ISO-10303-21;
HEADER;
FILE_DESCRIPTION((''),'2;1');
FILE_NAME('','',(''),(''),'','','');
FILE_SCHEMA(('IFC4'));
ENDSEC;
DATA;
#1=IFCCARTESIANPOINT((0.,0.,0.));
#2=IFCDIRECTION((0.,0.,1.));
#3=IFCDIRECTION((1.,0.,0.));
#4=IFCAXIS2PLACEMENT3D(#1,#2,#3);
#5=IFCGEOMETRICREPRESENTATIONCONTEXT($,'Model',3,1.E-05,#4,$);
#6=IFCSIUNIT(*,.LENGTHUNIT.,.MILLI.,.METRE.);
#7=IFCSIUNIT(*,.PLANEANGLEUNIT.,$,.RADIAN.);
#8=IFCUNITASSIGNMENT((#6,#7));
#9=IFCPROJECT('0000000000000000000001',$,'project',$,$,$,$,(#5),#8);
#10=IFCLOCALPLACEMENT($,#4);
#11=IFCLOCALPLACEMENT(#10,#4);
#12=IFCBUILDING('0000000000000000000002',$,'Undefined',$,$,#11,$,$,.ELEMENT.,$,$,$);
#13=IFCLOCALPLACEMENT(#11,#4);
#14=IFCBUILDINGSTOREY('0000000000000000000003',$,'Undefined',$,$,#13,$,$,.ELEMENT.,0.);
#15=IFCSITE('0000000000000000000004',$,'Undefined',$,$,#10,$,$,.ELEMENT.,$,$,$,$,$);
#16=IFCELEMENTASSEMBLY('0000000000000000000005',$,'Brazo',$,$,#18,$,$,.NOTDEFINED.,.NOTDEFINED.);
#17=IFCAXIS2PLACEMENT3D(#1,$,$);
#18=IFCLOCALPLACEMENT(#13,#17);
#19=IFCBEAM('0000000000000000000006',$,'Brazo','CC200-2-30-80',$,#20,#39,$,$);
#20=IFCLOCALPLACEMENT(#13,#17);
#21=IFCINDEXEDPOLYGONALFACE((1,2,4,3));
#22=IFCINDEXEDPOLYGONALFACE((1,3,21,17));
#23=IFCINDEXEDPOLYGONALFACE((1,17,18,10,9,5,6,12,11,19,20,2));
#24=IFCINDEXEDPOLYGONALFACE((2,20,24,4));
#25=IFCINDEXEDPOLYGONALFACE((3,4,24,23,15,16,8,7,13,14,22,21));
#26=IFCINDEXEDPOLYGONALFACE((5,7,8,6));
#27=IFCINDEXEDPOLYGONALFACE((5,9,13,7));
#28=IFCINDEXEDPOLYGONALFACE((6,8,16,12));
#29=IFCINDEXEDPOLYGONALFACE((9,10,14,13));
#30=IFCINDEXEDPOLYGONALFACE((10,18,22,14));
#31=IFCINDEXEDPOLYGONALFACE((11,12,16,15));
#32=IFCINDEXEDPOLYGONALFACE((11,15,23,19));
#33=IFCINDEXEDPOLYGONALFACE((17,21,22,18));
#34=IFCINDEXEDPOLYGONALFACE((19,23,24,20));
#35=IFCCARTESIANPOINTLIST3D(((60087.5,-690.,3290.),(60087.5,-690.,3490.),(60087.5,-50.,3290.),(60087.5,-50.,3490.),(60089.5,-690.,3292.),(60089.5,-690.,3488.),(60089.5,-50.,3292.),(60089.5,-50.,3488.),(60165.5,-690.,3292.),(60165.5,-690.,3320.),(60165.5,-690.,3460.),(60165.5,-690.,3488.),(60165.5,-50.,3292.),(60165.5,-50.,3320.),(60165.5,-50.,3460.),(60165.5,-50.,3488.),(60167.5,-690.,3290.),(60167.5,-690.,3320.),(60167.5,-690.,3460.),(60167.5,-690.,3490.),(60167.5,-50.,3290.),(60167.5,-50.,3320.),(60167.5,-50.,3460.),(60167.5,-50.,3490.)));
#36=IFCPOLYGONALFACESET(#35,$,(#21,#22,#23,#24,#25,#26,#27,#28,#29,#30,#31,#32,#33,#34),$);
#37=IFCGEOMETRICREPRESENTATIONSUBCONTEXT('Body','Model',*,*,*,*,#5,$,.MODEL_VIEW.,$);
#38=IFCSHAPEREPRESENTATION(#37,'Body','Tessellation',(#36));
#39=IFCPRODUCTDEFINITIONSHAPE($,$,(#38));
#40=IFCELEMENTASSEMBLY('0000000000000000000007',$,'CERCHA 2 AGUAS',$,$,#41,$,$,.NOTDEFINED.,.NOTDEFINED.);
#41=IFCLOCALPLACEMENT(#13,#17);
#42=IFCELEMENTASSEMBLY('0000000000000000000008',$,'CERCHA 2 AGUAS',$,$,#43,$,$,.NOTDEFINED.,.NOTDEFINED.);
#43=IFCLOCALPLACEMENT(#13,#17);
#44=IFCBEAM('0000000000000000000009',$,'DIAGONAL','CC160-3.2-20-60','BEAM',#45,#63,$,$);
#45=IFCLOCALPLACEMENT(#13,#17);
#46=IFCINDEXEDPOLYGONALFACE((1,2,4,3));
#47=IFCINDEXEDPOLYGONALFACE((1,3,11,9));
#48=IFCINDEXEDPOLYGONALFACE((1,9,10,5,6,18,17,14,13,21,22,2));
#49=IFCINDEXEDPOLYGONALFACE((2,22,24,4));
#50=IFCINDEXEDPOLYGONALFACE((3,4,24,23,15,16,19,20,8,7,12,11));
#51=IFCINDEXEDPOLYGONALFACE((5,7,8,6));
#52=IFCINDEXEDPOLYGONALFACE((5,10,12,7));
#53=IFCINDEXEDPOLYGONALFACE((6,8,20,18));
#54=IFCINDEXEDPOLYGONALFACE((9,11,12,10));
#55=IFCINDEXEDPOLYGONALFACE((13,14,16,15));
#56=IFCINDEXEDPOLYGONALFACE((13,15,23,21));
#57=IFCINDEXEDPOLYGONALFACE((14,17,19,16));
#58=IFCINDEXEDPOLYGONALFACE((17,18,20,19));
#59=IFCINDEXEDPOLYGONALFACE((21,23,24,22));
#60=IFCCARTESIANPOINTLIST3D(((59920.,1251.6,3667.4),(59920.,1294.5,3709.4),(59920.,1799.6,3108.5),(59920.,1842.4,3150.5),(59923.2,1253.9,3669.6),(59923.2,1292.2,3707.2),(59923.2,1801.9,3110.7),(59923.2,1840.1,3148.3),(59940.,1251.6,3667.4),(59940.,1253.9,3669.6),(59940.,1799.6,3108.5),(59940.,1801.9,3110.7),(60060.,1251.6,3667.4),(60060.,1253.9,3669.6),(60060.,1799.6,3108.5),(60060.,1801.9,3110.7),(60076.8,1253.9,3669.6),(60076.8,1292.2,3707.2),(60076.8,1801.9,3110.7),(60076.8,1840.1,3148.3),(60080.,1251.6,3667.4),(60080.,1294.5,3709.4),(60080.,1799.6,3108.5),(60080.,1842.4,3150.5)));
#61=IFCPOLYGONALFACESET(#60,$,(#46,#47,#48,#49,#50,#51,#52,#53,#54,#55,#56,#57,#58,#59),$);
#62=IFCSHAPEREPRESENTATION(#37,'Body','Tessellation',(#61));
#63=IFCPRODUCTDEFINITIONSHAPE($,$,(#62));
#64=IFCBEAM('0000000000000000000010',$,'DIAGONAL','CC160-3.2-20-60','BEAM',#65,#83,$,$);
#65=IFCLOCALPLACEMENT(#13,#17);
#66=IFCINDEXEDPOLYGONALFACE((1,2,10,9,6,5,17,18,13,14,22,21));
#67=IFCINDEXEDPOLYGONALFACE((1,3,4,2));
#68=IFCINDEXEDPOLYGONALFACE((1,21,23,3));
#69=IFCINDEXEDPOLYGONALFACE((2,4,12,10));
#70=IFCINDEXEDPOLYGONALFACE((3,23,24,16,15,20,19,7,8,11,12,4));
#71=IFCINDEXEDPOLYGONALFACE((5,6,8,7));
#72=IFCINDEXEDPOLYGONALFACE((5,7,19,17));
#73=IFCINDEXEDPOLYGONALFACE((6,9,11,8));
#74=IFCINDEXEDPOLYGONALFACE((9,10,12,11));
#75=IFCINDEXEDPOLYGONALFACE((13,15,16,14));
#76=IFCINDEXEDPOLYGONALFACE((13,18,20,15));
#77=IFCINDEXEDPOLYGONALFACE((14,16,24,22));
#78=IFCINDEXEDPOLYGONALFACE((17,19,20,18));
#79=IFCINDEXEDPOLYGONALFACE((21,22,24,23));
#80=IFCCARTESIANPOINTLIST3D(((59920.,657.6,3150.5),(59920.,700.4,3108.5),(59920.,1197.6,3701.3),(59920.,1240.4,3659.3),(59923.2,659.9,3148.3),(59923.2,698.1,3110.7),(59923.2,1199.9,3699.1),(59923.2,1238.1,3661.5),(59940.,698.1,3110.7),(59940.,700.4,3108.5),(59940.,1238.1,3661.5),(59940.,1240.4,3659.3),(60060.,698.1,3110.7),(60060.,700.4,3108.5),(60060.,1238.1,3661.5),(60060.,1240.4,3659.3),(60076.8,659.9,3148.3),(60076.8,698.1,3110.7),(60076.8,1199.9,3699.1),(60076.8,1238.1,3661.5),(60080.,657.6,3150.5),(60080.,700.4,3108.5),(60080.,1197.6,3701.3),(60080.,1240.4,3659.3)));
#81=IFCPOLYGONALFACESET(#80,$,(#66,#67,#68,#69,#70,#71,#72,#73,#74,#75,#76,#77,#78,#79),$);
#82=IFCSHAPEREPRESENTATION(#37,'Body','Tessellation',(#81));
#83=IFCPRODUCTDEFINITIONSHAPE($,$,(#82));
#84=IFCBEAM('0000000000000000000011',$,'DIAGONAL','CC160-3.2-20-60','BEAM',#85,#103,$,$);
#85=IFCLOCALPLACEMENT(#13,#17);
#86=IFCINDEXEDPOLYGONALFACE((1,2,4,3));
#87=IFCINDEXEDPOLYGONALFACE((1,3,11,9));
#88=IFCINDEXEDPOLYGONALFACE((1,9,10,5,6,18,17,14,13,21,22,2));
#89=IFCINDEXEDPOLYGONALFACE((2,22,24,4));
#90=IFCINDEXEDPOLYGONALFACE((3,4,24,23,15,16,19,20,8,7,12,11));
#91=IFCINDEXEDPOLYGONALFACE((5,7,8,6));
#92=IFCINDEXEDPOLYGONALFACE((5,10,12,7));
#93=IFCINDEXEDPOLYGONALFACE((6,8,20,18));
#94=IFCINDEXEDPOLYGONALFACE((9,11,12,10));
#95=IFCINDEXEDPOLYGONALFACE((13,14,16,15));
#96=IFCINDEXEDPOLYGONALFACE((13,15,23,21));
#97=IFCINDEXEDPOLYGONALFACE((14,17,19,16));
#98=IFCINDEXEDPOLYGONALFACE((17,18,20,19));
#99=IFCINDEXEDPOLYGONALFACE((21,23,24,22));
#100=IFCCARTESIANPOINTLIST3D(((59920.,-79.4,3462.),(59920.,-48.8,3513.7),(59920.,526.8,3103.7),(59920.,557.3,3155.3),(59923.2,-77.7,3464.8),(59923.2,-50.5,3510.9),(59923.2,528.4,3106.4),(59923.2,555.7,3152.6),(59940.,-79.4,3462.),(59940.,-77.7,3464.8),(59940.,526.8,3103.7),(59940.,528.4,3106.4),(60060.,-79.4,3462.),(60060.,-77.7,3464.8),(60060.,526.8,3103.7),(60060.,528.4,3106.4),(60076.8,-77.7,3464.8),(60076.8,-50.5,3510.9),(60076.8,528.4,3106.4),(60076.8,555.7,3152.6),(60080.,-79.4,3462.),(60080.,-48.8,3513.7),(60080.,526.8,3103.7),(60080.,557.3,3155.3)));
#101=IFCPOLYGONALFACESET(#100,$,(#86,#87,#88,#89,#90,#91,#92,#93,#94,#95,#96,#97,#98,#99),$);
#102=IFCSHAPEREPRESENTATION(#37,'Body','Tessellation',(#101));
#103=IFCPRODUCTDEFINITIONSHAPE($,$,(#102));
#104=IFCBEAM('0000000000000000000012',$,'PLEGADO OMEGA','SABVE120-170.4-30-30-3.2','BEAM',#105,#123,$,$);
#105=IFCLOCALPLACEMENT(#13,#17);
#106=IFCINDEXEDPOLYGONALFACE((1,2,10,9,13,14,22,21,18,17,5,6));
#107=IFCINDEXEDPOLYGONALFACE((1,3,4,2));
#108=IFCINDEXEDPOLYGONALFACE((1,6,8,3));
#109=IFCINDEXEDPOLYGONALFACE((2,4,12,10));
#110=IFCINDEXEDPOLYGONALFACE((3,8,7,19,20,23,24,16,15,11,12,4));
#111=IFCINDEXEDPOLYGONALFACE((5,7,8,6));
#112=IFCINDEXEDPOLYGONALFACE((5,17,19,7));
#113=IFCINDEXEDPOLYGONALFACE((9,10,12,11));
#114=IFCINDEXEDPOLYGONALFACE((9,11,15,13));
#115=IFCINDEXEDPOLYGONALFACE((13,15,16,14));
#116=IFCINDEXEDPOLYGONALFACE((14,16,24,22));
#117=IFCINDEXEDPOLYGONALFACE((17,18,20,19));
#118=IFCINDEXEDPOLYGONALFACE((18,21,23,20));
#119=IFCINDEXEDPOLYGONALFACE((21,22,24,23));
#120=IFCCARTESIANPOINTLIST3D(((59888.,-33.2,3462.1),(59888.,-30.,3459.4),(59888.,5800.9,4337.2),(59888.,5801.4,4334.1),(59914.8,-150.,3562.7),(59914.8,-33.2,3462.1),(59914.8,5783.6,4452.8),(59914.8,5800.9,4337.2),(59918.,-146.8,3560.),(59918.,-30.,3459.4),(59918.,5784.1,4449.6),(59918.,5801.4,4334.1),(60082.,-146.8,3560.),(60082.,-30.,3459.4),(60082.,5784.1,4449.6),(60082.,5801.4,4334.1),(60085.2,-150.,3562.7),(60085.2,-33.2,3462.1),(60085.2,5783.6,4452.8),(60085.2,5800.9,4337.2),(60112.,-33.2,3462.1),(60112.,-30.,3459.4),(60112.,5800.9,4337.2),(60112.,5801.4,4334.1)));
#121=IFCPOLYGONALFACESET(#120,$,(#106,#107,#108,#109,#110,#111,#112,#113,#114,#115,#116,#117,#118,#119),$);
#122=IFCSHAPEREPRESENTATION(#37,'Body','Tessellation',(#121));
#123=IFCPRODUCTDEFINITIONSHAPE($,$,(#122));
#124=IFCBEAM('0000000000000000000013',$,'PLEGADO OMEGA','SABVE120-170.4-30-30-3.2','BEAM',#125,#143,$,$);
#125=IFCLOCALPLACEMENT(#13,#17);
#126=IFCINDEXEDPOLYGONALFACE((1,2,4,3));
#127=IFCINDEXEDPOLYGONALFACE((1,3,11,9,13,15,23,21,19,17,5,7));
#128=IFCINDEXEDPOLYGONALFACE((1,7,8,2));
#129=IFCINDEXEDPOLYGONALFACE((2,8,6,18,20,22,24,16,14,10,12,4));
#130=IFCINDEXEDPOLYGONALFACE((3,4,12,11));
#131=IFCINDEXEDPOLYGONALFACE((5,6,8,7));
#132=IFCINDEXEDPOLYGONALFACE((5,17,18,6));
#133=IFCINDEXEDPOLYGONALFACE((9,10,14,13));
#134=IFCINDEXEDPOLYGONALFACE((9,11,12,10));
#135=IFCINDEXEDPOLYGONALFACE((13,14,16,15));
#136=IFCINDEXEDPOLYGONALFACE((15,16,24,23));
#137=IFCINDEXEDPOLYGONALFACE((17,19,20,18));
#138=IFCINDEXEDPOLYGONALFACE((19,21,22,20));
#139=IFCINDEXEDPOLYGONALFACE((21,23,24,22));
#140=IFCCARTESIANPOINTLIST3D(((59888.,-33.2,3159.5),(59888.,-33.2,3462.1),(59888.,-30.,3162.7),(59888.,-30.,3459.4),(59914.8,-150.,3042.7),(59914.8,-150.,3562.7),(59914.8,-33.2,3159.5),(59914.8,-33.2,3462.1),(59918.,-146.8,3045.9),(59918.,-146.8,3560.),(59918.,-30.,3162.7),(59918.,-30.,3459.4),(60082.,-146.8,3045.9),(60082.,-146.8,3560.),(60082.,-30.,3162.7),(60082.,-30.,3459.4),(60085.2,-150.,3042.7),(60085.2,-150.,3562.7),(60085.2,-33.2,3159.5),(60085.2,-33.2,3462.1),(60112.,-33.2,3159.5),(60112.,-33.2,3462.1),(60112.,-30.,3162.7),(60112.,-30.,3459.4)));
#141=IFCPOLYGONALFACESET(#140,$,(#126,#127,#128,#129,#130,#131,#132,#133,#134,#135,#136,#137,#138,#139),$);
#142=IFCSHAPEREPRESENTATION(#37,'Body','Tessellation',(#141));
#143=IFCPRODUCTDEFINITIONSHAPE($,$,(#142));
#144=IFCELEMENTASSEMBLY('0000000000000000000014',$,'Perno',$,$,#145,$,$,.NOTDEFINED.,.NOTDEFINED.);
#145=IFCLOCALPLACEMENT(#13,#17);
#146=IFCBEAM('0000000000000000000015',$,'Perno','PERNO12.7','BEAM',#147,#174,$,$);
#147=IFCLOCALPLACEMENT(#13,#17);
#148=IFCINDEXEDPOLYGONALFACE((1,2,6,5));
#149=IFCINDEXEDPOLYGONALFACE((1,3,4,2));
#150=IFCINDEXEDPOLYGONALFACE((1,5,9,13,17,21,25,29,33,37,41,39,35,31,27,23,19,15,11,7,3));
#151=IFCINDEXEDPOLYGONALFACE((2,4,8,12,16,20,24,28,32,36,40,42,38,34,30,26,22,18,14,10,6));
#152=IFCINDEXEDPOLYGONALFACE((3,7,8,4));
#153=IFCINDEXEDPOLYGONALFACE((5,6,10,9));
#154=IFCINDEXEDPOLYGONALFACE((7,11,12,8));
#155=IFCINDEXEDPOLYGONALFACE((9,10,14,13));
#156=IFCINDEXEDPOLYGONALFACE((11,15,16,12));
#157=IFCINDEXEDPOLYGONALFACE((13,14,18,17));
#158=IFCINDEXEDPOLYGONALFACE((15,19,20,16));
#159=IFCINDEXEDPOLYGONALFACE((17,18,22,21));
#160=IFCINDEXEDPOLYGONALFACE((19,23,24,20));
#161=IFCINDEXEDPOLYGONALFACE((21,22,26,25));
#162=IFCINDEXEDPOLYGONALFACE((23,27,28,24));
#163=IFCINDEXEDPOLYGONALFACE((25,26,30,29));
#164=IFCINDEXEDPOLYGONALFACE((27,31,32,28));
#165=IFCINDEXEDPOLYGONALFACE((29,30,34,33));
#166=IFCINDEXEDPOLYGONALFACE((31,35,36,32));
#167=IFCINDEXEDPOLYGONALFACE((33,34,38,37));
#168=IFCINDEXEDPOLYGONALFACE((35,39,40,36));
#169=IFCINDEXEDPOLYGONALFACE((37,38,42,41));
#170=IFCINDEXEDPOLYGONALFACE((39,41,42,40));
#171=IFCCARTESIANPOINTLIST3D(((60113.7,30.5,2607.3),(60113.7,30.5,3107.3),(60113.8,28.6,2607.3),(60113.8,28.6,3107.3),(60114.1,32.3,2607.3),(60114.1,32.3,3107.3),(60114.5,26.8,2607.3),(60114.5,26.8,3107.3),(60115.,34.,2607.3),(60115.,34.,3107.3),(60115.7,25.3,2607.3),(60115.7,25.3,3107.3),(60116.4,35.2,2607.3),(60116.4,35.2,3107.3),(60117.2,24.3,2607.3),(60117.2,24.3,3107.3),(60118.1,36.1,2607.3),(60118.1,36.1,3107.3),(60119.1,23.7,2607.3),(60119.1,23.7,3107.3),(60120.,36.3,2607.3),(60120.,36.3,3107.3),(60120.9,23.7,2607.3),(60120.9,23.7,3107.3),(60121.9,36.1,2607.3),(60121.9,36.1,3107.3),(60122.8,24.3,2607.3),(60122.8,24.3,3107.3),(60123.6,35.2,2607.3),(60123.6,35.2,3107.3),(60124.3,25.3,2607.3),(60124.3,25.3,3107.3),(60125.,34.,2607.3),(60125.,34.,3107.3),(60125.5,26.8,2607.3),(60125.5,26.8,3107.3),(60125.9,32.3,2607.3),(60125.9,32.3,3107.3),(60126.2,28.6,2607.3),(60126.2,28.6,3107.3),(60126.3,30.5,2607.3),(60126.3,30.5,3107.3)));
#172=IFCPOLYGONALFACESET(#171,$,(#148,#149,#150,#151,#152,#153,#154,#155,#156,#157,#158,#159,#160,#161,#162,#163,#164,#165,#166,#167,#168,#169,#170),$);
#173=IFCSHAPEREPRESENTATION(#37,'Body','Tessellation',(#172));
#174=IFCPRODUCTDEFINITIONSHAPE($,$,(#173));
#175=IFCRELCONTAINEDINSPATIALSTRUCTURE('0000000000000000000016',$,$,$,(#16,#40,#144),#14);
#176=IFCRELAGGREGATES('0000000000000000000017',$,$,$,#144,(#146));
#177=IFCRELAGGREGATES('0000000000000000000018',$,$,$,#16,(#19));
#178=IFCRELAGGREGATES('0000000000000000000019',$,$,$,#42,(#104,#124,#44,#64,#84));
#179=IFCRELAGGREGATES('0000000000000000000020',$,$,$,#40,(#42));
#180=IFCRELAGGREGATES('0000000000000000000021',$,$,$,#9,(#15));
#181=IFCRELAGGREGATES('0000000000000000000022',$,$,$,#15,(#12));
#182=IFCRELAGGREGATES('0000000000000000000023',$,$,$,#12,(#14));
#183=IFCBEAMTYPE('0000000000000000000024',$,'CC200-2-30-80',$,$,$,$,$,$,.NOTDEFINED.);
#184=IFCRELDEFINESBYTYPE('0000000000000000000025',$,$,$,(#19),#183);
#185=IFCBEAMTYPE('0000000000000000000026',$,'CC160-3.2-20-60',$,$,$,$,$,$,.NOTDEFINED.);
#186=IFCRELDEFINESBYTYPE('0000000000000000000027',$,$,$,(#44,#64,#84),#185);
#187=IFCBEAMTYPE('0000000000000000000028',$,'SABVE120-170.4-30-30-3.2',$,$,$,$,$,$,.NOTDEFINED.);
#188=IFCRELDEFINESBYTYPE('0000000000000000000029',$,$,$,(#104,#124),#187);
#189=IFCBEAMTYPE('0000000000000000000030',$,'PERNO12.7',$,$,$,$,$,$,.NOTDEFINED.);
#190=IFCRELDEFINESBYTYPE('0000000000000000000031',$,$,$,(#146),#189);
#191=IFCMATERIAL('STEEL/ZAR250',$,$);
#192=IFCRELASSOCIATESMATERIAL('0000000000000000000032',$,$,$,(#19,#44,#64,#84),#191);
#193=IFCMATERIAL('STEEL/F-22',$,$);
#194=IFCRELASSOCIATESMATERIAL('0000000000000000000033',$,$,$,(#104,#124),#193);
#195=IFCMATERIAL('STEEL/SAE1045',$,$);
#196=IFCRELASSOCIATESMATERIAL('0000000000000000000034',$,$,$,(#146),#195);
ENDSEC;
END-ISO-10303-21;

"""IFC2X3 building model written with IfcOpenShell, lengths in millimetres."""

from ifc_helpers import new_model, si_unit, frame, origin_with_axes, origin_2d_with_axis, place, context, subcontext, project, spatial, polyline, circle, c_section, outline, extrude, clip, halfspace, material, type_object, element, aggregate, save


model = new_model("IFC2X3")

# Units and contexts
model_context = context("Model", 3, precision=1e-05, world=origin_with_axes())
body_context = subcontext(model_context, "Body", "Model", "MODEL_VIEW")
ifc_project = project(units=[si_unit("LENGTHUNIT", "METRE", prefix="MILLI"), si_unit("PLANEANGLEUNIT", "RADIAN")], contexts=[model_context])

# Site, building, storey
site_placement = place(None, origin_with_axes())
site = spatial("IfcSite", under=ifc_project, at=site_placement, Name="Undefined", CompositionType="ELEMENT")
building_placement = place(site_placement, origin_with_axes())
building = spatial("IfcBuilding", under=site, at=building_placement, Name="Undefined", CompositionType="ELEMENT")
storey_placement = place(building_placement, origin_with_axes())
storey = spatial("IfcBuildingStorey", under=building, at=storey_placement, Name="Undefined", CompositionType="ELEMENT", Elevation=0.0)

# Element assembly, beam
assembly_1_placement = place(storey_placement, origin_with_axes())
assembly_1 = element("IfcElementAssembly", 1, at=assembly_1_placement, inside=storey, Name="Brazo", AssemblyPlace="NOTDEFINED", PredefinedType="NOTDEFINED")
ifc_material_1 = material(Name="STEEL/ZAR250")
beam_type_1 = type_object("IfcBeamType", Name="CC200-2-30-80", PredefinedType="NOTDEFINED")
beam_1_placement = place(assembly_1_placement, frame((60127.5, -50.0, 3390.0), z_axis=(0.0, 0.000005, -1.0), x_axis=(-0.000004, -1.0, -0.000005)))
beam_1 = element("IfcBeam", 2, at=beam_1_placement, type_object=beam_type_1, material=ifc_material_1, Name="Brazo", Description="CC200-2-30-80", context=body_context, shape_type="SweptSolid", body=[
    extrude(c_section(Depth=200.0, Width=80.0, WallThickness=2.0, Girth=30.0, at=origin_2d_with_axis()), frame((640.0, 0.0, 0.0), z_axis=(-1.0, 0.0, 0.0), x_axis=(0.0, -1.0, 0.0)), (0.0, 0.0, 1.0), 640.0),
])

# Element assemblies, beams
assembly_2_placement = place(storey_placement, origin_with_axes())
assembly_2 = element("IfcElementAssembly", 3, at=assembly_2_placement, inside=storey, Name="CERCHA 2 AGUAS", AssemblyPlace="NOTDEFINED", PredefinedType="NOTDEFINED")
assembly_3_placement = place(assembly_2_placement, origin_with_axes())
assembly_3 = element("IfcElementAssembly", 4, at=assembly_3_placement, Name="CERCHA 2 AGUAS", AssemblyPlace="NOTDEFINED", PredefinedType="NOTDEFINED")
beam_type_2 = type_object("IfcBeamType", Name="CC160-3.2-20-60", PredefinedType="NOTDEFINED")
beam_2_placement = place(assembly_3_placement, frame((60000.0, 1273.1, 3688.4), z_axis=(1.0, 0.0, 0.0), x_axis=(0.0, 0.700071, -0.714073)))
beam_2 = element("IfcBeam", 5, at=beam_2_placement, type_object=beam_type_2, material=ifc_material_1, Name="DIAGONAL", Description="CC160-3.2-20-60", ObjectType="BEAM", context=body_context, shape_type="SweptSolid", body=[
    extrude(c_section(Depth=160.0, Width=60.0, WallThickness=3.2, Girth=20.0, at=origin_2d_with_axis()), frame((782.7, 0.0, 0.0), z_axis=(-1.0, 0.0, 0.0), x_axis=(0.0, -1.0, 0.0)), (0.0, 0.0, 1.0), 782.7),
])
beam_3_placement = place(assembly_3_placement, frame((60000.0, 679.0, 3129.5), z_axis=(1.0, 0.0, 0.0), x_axis=(0.0, 0.700071, 0.714073)))
beam_3 = element("IfcBeam", 6, at=beam_3_placement, type_object=beam_type_2, material=ifc_material_1, Name="DIAGONAL", Description="CC160-3.2-20-60", ObjectType="BEAM", context=body_context, shape_type="SweptSolid", body=[
    extrude(c_section(Depth=160.0, Width=60.0, WallThickness=3.2, Girth=20.0, at=origin_2d_with_axis()), frame((771.3, 0.0, 0.0), z_axis=(-1.0, 0.0, 0.0), x_axis=(0.0, -1.0, 0.0)), (0.0, 0.0, 1.0), 771.3),
])
beam_4_placement = place(assembly_3_placement, frame((60000.0, -64.1, 3487.8), z_axis=(1.0, 0.0, 0.0), x_axis=(0.0, 0.860828, -0.508895)))
beam_4 = element("IfcBeam", 7, at=beam_4_placement, type_object=beam_type_2, material=ifc_material_1, Name="DIAGONAL", Description="CC160-3.2-20-60", ObjectType="BEAM", context=body_context, shape_type="SweptSolid", body=[
    extrude(c_section(Depth=160.0, Width=60.0, WallThickness=3.2, Girth=20.0, at=origin_2d_with_axis()), frame((704.1, 0.0, 0.0), z_axis=(-1.0, 0.0, 0.0), x_axis=(0.0, -1.0, 0.0)), (0.0, 0.0, 1.0), 704.1),
])
ifc_material_2 = material(Name="STEEL/F-22")
beam_type_3 = type_object("IfcBeamType", Name="SABVE120-170.4-30-30-3.2", PredefinedType="NOTDEFINED")
beam_5_placement = place(assembly_3_placement, frame((60000.0, -141.1, 3503.4), z_axis=(0.0, 0.14834, -0.988936), x_axis=(0.0, 0.988936, 0.14834)))
beam_5 = element("IfcBeam", 8, at=beam_5_placement, type_object=beam_type_3, material=ifc_material_2, Name="PLEGADO OMEGA", Description="SABVE120-170.4-30-30-3.2", ObjectType="BEAM", context=body_context, shape_type="Clipping", body=[
    clip(extrude(outline(polyline([(82.0, 60.0), (112.0, 60.0), (112.0, 56.8), (85.2, 56.8), (85.2, -60.0), (-85.2, -60.0), (-85.2, 56.8), (-112.0, 56.8), (-112.0, 60.0), (-82.0, 60.0), (-82.0, -56.8), (82.0, -56.8), (82.0, 60.0)])), frame((6000.0, 0.0, 0.0), z_axis=(-1.0, 0.0, 0.0), x_axis=(0.0, -1.0, 0.0)), (0.0, 0.0, 1.0), 6033.8), halfspace(frame((0.0, 0.0, -60.0), z_axis=(-0.757741, 0.0, 0.652555), x_axis=(0.0, 1.0, 0.0)), False)),
])
beam_6_placement = place(assembly_3_placement, frame((60000.0, -90.0, 3042.7), z_axis=(0.0, 1.0, -0.000004), x_axis=(0.0, 0.000004, 1.0)))
beam_6 = element("IfcBeam", 9, at=beam_6_placement, type_object=beam_type_3, material=ifc_material_2, Name="PLEGADO OMEGA", Description="SABVE120-170.4-30-30-3.2", ObjectType="BEAM", context=body_context, shape_type="Clipping", body=[
    clip(clip(extrude(outline(polyline([(82.0, 60.0), (112.0, 60.0), (112.0, 56.8), (85.2, 56.8), (85.2, -60.0), (-85.2, -60.0), (-85.2, 56.8), (-112.0, 56.8), (-112.0, 60.0), (-82.0, 60.0), (-82.0, -56.8), (82.0, -56.8), (82.0, 60.0)])), frame((581.1, 0.0, 0.0), z_axis=(-1.0, 0.0, 0.0), x_axis=(0.0, -1.0, 0.0)), (0.0, 0.0, 1.0), 633.9), halfspace(frame((520.0, 0.0, -60.0), z_axis=(-0.757741, 0.0, -0.652555), x_axis=(0.0, 1.0, 0.0)), True)), halfspace(frame((120.0, 0.0, 60.0), z_axis=(0.707106, 0.0, -0.707108), x_axis=(0.0, 1.0, 0.0)), True)),
])

# Element assembly, beam
assembly_4_placement = place(storey_placement, origin_with_axes())
assembly_4 = element("IfcElementAssembly", 10, at=assembly_4_placement, inside=storey, Name="Perno", AssemblyPlace="NOTDEFINED", PredefinedType="NOTDEFINED")
ifc_material_3 = material(Name="STEEL/SAE1045")
beam_type_4 = type_object("IfcBeamType", Name="PERNO12.7", PredefinedType="NOTDEFINED")
beam_7_placement = place(assembly_4_placement, frame((60120.0, 30.0, 3107.3), z_axis=(-1.0, 0.0, 0.0), x_axis=(0.0, 0.0, -1.0)))
beam_7 = element("IfcBeam", 11, at=beam_7_placement, type_object=beam_type_4, material=ifc_material_3, Name="Perno", Description="PERNO12.7", ObjectType="BEAM", context=body_context, shape_type="SweptSolid", body=[
    extrude(circle(Radius=6.3, at=origin_2d_with_axis()), frame((500.0, 0.0, 0.0), z_axis=(-1.0, 0.0, 0.0), x_axis=(0.0, -1.0, 0.0)), (0.0, 0.0, 1.0), 500.0),
])
aggregate(assembly_4, [beam_7])

aggregate(assembly_1, [beam_1])

aggregate(assembly_3, [beam_5, beam_6, beam_2, beam_3, beam_4])

aggregate(assembly_2, [assembly_3])

save(model, "model.ifc")
